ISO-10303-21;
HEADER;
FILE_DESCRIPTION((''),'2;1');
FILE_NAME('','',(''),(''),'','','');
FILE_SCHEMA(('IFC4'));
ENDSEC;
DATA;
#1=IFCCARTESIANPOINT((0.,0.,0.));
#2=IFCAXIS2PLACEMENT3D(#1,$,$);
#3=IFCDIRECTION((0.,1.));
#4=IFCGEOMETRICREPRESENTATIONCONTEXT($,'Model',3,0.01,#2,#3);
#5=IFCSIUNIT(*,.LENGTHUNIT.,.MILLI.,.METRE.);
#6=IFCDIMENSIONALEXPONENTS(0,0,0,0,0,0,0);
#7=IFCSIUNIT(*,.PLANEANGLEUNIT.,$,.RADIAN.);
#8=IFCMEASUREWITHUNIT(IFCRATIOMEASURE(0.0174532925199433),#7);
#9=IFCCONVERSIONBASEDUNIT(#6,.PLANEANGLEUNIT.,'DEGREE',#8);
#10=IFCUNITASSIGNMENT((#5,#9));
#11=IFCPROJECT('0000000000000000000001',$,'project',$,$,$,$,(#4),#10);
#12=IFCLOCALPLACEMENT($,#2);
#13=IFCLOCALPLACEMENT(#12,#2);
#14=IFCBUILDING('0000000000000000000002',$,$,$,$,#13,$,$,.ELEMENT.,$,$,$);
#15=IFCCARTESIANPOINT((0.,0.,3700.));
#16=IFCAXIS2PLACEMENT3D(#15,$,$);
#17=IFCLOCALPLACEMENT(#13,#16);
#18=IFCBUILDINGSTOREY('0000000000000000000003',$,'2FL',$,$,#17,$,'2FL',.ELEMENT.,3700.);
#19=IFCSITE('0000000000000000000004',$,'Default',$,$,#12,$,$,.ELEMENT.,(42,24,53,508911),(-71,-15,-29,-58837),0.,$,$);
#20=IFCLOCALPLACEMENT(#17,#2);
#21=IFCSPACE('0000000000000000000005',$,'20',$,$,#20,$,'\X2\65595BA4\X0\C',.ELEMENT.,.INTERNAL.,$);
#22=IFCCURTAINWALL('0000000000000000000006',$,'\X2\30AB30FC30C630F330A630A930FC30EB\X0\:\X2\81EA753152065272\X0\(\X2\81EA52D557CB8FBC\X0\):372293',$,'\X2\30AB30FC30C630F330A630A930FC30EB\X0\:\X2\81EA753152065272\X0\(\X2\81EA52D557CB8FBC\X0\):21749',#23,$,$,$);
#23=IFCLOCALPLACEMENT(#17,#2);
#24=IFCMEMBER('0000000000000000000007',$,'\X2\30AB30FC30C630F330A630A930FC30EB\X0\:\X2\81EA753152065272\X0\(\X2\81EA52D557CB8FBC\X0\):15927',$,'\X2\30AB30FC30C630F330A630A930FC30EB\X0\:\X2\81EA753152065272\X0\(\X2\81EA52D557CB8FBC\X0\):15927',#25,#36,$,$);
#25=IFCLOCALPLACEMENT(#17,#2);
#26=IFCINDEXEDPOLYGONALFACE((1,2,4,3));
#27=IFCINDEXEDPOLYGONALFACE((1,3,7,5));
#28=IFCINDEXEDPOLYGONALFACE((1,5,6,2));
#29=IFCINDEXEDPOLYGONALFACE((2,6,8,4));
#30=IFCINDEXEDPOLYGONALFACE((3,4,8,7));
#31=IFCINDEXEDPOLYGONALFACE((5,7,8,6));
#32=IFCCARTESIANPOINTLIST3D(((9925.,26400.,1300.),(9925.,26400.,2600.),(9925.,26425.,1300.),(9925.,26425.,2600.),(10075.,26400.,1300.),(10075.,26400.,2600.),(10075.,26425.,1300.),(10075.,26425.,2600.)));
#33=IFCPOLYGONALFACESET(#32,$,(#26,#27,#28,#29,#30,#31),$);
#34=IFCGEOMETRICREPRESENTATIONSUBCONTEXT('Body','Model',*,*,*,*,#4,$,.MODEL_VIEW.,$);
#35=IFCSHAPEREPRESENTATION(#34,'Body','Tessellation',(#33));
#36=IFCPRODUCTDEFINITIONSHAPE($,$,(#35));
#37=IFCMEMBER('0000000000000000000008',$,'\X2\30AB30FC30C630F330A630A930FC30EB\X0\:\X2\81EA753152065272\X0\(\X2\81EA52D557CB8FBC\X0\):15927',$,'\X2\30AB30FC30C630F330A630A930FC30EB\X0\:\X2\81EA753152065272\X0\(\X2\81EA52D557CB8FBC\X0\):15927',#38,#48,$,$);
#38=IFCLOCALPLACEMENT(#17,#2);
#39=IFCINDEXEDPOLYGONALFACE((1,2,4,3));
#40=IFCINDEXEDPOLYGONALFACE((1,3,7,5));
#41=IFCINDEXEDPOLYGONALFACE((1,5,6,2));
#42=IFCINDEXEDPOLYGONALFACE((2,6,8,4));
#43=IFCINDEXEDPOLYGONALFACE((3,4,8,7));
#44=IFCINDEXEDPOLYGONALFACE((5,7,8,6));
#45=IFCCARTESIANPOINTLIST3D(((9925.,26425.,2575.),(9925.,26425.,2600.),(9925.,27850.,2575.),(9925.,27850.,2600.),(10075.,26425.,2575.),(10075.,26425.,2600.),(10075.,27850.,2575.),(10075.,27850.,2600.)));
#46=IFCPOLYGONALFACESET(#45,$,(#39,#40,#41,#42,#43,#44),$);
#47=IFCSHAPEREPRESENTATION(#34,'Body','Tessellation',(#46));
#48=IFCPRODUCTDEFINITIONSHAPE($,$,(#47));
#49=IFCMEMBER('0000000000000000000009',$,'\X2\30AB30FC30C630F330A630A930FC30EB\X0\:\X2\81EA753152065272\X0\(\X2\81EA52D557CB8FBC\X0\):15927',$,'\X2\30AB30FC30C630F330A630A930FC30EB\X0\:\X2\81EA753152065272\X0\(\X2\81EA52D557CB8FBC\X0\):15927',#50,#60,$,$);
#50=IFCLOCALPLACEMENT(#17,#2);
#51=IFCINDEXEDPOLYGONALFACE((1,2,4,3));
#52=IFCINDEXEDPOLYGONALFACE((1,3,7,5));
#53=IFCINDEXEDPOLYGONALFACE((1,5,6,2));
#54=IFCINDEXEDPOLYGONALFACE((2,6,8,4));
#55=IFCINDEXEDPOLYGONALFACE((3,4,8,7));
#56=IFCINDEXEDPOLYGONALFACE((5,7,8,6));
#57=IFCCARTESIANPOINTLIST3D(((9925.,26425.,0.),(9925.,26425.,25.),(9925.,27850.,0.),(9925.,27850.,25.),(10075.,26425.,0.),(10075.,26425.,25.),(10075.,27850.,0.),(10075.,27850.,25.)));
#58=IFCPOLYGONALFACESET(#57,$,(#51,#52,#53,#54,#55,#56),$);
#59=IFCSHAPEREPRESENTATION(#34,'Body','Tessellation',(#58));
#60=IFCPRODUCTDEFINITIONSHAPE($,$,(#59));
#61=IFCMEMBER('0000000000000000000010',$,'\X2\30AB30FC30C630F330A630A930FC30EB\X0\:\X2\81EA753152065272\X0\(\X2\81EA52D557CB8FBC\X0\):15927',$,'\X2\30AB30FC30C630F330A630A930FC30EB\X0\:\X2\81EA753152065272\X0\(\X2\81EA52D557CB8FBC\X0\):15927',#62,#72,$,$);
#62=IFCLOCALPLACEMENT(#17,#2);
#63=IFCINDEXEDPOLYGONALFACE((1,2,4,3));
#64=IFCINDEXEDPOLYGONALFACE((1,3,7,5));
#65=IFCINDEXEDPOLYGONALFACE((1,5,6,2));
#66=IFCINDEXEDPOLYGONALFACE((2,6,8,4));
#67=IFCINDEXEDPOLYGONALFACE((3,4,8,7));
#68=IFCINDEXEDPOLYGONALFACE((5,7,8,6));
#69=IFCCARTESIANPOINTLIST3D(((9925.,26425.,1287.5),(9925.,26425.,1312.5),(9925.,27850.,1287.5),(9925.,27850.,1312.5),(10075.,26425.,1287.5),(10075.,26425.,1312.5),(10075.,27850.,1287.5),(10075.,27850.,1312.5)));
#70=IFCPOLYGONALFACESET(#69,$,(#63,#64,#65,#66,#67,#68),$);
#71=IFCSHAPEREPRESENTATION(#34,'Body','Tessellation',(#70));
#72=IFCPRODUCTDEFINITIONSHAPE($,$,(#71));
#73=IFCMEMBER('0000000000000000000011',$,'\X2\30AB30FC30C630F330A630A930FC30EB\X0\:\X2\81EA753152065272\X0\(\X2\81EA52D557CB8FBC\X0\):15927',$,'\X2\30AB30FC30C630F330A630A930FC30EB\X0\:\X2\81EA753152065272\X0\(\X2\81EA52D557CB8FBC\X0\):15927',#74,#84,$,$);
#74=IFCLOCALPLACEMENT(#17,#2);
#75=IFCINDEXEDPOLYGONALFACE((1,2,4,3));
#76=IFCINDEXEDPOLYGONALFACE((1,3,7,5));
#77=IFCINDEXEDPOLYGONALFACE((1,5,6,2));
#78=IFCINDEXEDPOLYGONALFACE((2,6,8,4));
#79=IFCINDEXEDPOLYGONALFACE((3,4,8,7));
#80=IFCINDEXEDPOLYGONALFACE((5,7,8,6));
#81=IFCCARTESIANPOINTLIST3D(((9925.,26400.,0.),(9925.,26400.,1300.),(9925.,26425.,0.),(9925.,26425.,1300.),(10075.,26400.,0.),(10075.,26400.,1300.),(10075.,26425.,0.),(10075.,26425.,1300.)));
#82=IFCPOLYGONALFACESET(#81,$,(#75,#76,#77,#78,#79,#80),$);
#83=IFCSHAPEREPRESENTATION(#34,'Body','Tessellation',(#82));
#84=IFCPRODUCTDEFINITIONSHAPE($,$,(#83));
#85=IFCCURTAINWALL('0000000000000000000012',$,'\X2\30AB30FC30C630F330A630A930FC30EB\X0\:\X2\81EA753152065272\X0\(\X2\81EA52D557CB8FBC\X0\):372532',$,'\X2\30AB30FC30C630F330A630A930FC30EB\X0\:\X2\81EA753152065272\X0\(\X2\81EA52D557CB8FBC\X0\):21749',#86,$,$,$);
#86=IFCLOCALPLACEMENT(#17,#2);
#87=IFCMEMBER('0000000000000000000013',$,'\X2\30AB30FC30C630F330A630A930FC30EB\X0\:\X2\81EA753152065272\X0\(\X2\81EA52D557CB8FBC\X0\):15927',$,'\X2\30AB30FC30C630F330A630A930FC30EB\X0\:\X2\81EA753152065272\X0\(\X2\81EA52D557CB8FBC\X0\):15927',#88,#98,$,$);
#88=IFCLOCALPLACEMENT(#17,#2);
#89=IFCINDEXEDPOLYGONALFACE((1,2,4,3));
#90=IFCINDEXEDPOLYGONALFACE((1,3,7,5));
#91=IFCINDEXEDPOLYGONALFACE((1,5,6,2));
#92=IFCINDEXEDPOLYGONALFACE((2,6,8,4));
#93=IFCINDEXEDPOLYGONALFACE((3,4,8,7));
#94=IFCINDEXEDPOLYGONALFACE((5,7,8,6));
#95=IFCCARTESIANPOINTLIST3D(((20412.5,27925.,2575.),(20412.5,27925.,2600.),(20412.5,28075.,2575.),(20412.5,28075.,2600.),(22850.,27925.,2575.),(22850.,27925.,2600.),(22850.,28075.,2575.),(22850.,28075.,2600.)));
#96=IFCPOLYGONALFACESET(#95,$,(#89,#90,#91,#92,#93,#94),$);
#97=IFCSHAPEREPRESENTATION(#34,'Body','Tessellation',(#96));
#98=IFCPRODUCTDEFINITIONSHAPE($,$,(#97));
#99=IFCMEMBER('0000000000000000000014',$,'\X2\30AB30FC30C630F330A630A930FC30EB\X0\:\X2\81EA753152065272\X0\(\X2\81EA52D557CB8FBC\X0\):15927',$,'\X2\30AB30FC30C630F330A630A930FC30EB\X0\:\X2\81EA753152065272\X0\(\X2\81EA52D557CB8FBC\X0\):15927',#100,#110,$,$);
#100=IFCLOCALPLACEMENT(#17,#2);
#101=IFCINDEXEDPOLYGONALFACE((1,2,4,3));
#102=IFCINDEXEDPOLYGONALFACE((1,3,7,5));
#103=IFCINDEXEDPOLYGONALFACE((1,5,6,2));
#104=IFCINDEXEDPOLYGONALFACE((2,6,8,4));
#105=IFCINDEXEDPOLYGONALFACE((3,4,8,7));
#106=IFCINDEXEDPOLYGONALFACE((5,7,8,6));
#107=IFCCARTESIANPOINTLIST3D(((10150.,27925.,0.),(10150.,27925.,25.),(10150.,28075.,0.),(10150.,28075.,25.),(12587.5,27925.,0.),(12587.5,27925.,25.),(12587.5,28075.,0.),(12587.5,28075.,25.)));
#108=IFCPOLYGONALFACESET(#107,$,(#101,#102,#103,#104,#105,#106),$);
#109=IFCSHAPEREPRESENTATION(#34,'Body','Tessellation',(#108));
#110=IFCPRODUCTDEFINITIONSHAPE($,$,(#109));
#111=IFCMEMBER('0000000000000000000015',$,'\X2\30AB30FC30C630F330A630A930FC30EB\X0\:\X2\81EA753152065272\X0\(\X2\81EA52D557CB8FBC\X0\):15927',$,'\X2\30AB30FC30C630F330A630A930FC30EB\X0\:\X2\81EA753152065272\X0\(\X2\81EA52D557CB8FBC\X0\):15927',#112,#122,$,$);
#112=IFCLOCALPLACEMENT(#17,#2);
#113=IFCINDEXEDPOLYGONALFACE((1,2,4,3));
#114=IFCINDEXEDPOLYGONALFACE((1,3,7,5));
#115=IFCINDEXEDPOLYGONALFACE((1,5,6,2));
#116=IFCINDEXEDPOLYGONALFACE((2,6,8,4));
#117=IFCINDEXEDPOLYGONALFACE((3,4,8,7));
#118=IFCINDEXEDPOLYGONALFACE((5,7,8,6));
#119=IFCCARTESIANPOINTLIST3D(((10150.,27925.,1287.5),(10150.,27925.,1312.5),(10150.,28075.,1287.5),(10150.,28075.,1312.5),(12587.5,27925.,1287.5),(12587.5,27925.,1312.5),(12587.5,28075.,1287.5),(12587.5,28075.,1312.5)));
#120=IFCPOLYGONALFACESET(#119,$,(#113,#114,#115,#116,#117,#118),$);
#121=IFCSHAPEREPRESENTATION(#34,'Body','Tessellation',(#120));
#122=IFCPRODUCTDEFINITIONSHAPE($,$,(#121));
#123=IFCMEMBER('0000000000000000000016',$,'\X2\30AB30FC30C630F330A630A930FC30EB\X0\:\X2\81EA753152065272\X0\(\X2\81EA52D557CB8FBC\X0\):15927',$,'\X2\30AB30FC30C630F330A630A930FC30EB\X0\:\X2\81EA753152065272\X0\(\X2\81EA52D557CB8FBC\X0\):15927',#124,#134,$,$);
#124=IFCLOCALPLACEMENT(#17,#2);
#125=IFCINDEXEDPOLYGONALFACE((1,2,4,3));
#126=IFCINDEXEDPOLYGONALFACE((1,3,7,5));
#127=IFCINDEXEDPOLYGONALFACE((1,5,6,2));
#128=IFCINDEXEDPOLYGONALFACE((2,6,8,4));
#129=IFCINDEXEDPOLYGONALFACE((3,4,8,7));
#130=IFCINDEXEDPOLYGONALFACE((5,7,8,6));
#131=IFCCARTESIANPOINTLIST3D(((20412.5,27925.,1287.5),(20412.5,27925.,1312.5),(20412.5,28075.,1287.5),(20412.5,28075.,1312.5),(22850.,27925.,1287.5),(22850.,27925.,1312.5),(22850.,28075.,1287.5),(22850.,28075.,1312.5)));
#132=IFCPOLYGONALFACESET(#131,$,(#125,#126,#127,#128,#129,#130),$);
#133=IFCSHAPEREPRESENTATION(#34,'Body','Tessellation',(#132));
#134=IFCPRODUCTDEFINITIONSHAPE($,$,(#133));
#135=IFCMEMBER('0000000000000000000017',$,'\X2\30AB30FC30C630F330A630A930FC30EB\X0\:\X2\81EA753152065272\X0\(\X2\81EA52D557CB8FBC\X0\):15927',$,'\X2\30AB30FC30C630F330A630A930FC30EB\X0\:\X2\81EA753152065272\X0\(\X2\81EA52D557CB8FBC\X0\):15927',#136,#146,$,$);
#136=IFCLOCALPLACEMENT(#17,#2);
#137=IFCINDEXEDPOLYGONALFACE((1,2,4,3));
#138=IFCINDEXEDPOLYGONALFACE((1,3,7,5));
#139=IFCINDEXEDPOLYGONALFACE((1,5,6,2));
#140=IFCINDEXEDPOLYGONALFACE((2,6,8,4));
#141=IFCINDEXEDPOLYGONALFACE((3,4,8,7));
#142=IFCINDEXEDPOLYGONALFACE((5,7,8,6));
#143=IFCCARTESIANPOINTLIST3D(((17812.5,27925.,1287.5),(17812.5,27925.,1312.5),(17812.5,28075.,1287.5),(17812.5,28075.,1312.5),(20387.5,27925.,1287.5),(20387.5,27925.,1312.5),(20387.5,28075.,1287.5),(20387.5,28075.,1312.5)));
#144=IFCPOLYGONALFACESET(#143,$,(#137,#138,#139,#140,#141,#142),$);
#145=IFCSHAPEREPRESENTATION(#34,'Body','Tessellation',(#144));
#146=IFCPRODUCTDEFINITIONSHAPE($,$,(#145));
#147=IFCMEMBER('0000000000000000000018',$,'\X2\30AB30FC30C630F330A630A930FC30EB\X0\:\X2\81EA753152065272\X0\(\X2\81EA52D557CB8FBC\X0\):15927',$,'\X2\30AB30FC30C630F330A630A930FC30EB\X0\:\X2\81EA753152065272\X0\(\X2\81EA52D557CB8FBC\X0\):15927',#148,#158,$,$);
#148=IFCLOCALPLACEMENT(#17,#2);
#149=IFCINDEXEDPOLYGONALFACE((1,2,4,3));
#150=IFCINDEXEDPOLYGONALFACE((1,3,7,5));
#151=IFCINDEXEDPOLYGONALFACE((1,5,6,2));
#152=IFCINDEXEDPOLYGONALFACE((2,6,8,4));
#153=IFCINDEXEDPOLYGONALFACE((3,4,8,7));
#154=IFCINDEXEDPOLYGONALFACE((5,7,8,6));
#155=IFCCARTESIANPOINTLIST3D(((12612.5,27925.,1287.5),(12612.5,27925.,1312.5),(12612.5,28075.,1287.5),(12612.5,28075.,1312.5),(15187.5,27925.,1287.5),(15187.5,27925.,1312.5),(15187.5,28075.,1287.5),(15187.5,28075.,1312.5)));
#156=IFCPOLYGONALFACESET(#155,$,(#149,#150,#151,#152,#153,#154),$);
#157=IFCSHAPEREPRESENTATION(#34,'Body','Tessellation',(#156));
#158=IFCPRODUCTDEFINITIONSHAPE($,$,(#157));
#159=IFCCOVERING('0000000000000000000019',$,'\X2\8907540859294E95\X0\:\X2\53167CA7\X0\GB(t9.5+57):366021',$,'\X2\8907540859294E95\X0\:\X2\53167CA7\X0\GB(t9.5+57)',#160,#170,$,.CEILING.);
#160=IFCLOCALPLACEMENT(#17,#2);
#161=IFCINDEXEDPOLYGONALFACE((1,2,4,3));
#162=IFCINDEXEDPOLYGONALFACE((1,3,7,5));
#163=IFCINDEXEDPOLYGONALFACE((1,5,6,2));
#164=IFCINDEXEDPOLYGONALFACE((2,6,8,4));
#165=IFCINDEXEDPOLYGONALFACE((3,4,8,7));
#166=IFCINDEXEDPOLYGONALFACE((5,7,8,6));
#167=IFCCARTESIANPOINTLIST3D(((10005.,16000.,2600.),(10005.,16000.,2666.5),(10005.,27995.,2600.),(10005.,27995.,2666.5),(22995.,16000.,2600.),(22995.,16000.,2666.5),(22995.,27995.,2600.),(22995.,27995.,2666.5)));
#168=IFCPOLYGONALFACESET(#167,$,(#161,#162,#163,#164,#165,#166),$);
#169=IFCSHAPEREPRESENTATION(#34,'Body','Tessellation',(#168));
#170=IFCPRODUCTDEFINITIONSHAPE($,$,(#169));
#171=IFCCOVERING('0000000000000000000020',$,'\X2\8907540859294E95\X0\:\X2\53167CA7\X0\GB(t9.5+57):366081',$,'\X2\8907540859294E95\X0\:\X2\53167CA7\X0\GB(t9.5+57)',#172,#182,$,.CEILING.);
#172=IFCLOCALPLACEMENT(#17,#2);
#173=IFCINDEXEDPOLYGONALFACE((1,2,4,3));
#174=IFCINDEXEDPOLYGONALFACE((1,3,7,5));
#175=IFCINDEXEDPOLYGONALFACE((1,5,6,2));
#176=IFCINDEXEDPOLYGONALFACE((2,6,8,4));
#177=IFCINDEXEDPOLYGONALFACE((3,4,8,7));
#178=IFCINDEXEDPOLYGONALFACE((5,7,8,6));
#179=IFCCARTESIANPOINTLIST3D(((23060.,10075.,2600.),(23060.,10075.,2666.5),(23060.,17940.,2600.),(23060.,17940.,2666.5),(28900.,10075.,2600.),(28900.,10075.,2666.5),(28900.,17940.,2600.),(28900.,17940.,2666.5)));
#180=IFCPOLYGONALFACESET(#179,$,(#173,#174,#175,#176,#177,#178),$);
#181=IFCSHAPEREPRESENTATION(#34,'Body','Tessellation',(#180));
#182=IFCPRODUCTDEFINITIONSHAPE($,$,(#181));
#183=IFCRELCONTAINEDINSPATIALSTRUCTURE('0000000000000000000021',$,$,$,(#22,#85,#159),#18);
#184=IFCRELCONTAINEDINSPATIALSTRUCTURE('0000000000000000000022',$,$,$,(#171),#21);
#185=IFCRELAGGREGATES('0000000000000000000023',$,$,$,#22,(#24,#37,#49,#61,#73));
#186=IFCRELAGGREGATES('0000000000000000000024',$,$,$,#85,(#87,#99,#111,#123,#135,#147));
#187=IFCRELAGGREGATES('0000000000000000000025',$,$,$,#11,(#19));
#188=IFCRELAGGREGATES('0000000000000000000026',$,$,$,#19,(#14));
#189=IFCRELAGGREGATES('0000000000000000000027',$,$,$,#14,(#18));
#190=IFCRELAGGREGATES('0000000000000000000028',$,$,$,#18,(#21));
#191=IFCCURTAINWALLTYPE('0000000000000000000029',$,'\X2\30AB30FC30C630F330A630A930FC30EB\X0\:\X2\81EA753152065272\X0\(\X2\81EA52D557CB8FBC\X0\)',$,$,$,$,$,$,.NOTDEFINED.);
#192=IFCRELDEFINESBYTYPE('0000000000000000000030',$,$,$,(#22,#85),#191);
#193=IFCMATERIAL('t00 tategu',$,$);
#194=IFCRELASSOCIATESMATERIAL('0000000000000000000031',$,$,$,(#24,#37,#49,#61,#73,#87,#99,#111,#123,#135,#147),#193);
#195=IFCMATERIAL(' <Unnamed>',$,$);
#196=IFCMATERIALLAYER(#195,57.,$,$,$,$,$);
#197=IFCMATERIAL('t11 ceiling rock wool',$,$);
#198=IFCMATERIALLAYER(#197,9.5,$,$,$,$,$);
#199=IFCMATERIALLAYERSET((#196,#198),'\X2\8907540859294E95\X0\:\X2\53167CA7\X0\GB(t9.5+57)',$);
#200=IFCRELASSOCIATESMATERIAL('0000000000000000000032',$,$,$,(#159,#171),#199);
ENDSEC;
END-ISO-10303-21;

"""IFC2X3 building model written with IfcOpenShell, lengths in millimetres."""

from ifc_helpers import new_model, entity, si_unit, converted_unit, direction, frame, frame_2d, origin, origin_2d_with_axis, place, context, subcontext, project, spatial, rectangle, extrude, material, layer, layer_set, layer_usage, type_object, element, aggregate, save


model = new_model("IFC2X3")

# Units and contexts
model_context = context("Model", 3, precision=0.01, world=origin(), true_north=direction((0.0, 1.0)))
body_context = subcontext(model_context, "Body", "Model", "MODEL_VIEW")
ifc_project = project(units=[si_unit("LENGTHUNIT", "METRE", prefix="MILLI"), converted_unit("PLANEANGLEUNIT", "DEGREE", entity("IfcRatioMeasure", 0.0174532925199433), si_unit("PLANEANGLEUNIT", "RADIAN"), dimensions=[0, 0, 0, 0, 0, 0, 0])], contexts=[model_context])

# Site, building, storey
site_placement = place(None, origin())
site = spatial("IfcSite", under=ifc_project, at=site_placement, Name="Default", CompositionType="ELEMENT", RefLatitude=(42, 24, 53, 508911), RefLongitude=(-71, -15, -29, -58837), RefElevation=0.0)
building_placement = place(site_placement, origin())
building = spatial("IfcBuilding", under=site, at=building_placement, CompositionType="ELEMENT")
storey_placement = place(building_placement, frame((0.0, 0.0, 3700.0)))
storey = spatial("IfcBuildingStorey", under=building, at=storey_placement, Name="2FL", LongName="2FL", CompositionType="ELEMENT", Elevation=3700.0)

# Curtain walls, members
curtain_wall_type = type_object("IfcCurtainWallType", Name="カーテンウォール:自由分割(自動埋込)", PredefinedType="NOTDEFINED")
curtain_wall_1_placement = place(storey_placement, frame((0.0, 0.0, -3700.0)))
curtain_wall_1 = element("IfcCurtainWall", 1, at=curtain_wall_1_placement, inside=storey, type_object=curtain_wall_type, Name="カーテンウォール:自由分割(自動埋込):372293", ObjectType="カーテンウォール:自由分割(自動埋込):21749")
ifc_material_1 = material(Name="t00 tategu")
member_1_placement = place(curtain_wall_1_placement, frame((0.0, 0.0, 3700.0)))
member_1 = element("IfcMember", 2, at=member_1_placement, material=ifc_material_1, Name="カーテンウォール:自由分割(自動埋込):15927", ObjectType="カーテンウォール:自由分割(自動埋込):15927", context=body_context, shape_type="SweptSolid", body=[
    extrude(rectangle(XDim=150.0, YDim=25.0, at=frame_2d((0.0, 0.0), x_axis=(1.0, 0.0))), frame((10000.0, 26412.5, 2600.0), z_axis=(0.0, 0.0, -1.0), x_axis=(-1.0, 0.0, 0.0)), (0.0, 0.0, 1.0), 1300.0),
])
member_2_placement = place(curtain_wall_1_placement, frame((0.0, 0.0, 3700.0)))
member_2 = element("IfcMember", 3, at=member_2_placement, material=ifc_material_1, Name="カーテンウォール:自由分割(自動埋込):15927", ObjectType="カーテンウォール:自由分割(自動埋込):15927", context=body_context, shape_type="SweptSolid", body=[
    extrude(rectangle(XDim=25.0, YDim=150.0, at=frame_2d((0.0, 0.0), x_axis=(1.0, 0.0))), frame((10000.0, 27850.0, 2587.5), z_axis=(0.0, -1.0, 0.0), x_axis=(0.0, 0.0, -1.0)), (0.0, 0.0, 1.0), 1425.0),
])
member_3_placement = place(curtain_wall_1_placement, frame((0.0, 0.0, 3700.0)))
member_3 = element("IfcMember", 4, at=member_3_placement, material=ifc_material_1, Name="カーテンウォール:自由分割(自動埋込):15927", ObjectType="カーテンウォール:自由分割(自動埋込):15927", context=body_context, shape_type="SweptSolid", body=[
    extrude(rectangle(XDim=25.0, YDim=150.0, at=origin_2d_with_axis()), frame((10000.0, 26425.0, 12.5), z_axis=(0.0, 1.0, 0.0), x_axis=(0.0, 0.0, -1.0)), (0.0, 0.0, 1.0), 1425.0),
])
member_4_placement = place(curtain_wall_1_placement, frame((0.0, 0.0, 3700.0)))
member_4 = element("IfcMember", 5, at=member_4_placement, material=ifc_material_1, Name="カーテンウォール:自由分割(自動埋込):15927", ObjectType="カーテンウォール:自由分割(自動埋込):15927", context=body_context, shape_type="SweptSolid", body=[
    extrude(rectangle(XDim=25.0, YDim=150.0, at=origin_2d_with_axis()), frame((10000.0, 27850.0, 1300.0), z_axis=(0.0, -1.0, 0.0), x_axis=(0.0, 0.0, -1.0)), (0.0, 0.0, 1.0), 1425.0),
])
member_5_placement = place(curtain_wall_1_placement, frame((0.0, 0.0, 3700.0)))
member_5 = element("IfcMember", 6, at=member_5_placement, material=ifc_material_1, Name="カーテンウォール:自由分割(自動埋込):15927", ObjectType="カーテンウォール:自由分割(自動埋込):15927", context=body_context, shape_type="SweptSolid", body=[
    extrude(rectangle(XDim=150.0, YDim=25.0, at=frame_2d((0.0, 0.0), x_axis=(1.0, 0.0))), frame((10000.0, 26412.5, 1300.0), z_axis=(0.0, 0.0, -1.0), x_axis=(-1.0, 0.0, 0.0)), (0.0, 0.0, 1.0), 1300.0),
])
aggregate(curtain_wall_1, [member_1, member_2, member_3, member_4, member_5])
curtain_wall_2_placement = place(storey_placement, frame((0.0, 0.0, -3700.0)))
curtain_wall_2 = element("IfcCurtainWall", 7, at=curtain_wall_2_placement, inside=storey, type_object=curtain_wall_type, Name="カーテンウォール:自由分割(自動埋込):372532", ObjectType="カーテンウォール:自由分割(自動埋込):21749")
member_6_placement = place(curtain_wall_2_placement, frame((0.0, 0.0, 3700.0)))
member_6 = element("IfcMember", 8, at=member_6_placement, material=ifc_material_1, Name="カーテンウォール:自由分割(自動埋込):15927", ObjectType="カーテンウォール:自由分割(自動埋込):15927", context=body_context, shape_type="SweptSolid", body=[
    extrude(rectangle(XDim=25.0, YDim=150.0, at=frame_2d((0.0, 0.0), x_axis=(1.0, 0.0))), frame((22850.0, 28000.0, 2587.5), z_axis=(-1.0, 0.0, 0.0), x_axis=(0.0, 0.0, -1.0)), (0.0, 0.0, 1.0), 2437.5),
])
member_7_placement = place(curtain_wall_2_placement, frame((0.0, 0.0, 3700.0)))
member_7 = element("IfcMember", 9, at=member_7_placement, material=ifc_material_1, Name="カーテンウォール:自由分割(自動埋込):15927", ObjectType="カーテンウォール:自由分割(自動埋込):15927", context=body_context, shape_type="SweptSolid", body=[
    extrude(rectangle(XDim=25.0, YDim=150.0, at=frame_2d((0.0, 0.0), x_axis=(1.0, 0.0))), frame((10150.0, 28000.0, 12.5), z_axis=(1.0, 0.0, 0.0), x_axis=(0.0, 0.0, -1.0)), (0.0, 0.0, 1.0), 2437.5),
])
member_8_placement = place(curtain_wall_2_placement, frame((0.0, 0.0, 3700.0)))
member_8 = element("IfcMember", 10, at=member_8_placement, material=ifc_material_1, Name="カーテンウォール:自由分割(自動埋込):15927", ObjectType="カーテンウォール:自由分割(自動埋込):15927", context=body_context, shape_type="SweptSolid", body=[
    extrude(rectangle(XDim=25.0, YDim=150.0, at=frame_2d((0.0, 0.0), x_axis=(1.0, 0.0))), frame((12587.5, 28000.0, 1300.0), z_axis=(-1.0, 0.0, 0.0), x_axis=(0.0, 0.0, -1.0)), (0.0, 0.0, 1.0), 2437.5),
])
member_9_placement = place(curtain_wall_2_placement, frame((0.0, 0.0, 3700.0)))
member_9 = element("IfcMember", 11, at=member_9_placement, material=ifc_material_1, Name="カーテンウォール:自由分割(自動埋込):15927", ObjectType="カーテンウォール:自由分割(自動埋込):15927", context=body_context, shape_type="SweptSolid", body=[
    extrude(rectangle(XDim=25.0, YDim=150.0, at=frame_2d((0.0, 0.0), x_axis=(1.0, 0.0))), frame((22850.0, 28000.0, 1300.0), z_axis=(-1.0, 0.0, 0.0), x_axis=(0.0, 0.0, -1.0)), (0.0, 0.0, 1.0), 2437.5),
])
member_10_placement = place(curtain_wall_2_placement, frame((0.0, 0.0, 3700.0)))
member_10 = element("IfcMember", 12, at=member_10_placement, material=ifc_material_1, Name="カーテンウォール:自由分割(自動埋込):15927", ObjectType="カーテンウォール:自由分割(自動埋込):15927", context=body_context, shape_type="SweptSolid", body=[
    extrude(rectangle(XDim=25.0, YDim=150.0, at=frame_2d((0.0, 0.0), x_axis=(1.0, 0.0))), frame((20387.5, 28000.0, 1300.0), z_axis=(-1.0, 0.0, 0.0), x_axis=(0.0, 0.0, -1.0)), (0.0, 0.0, 1.0), 2575.0),
])
member_11_placement = place(curtain_wall_2_placement, frame((0.0, 0.0, 3700.0)))
member_11 = element("IfcMember", 13, at=member_11_placement, material=ifc_material_1, Name="カーテンウォール:自由分割(自動埋込):15927", ObjectType="カーテンウォール:自由分割(自動埋込):15927", context=body_context, shape_type="SweptSolid", body=[
    extrude(rectangle(XDim=25.0, YDim=150.0, at=frame_2d((0.0, 0.0), x_axis=(1.0, 0.0))), frame((15187.5, 28000.0, 1300.0), z_axis=(-1.0, 0.0, 0.0), x_axis=(0.0, 0.0, -1.0)), (0.0, 0.0, 1.0), 2575.0),
])
aggregate(curtain_wall_2, [member_6, member_7, member_8, member_9, member_10, member_11])

# Covering
ifc_material_2 = material(Name=" <Unnamed>")
ifc_layer_1 = layer(ifc_material_2, 57.0)
ifc_material_3 = material(Name="t11 ceiling rock wool")
ifc_layer_2 = layer(ifc_material_3, 9.5)
ifc_layer_set = layer_set([ifc_layer_1, ifc_layer_2], Name="複合天井:化粧GB(t9.5+57)")
ifc_layer_usage_1 = layer_usage(ifc_layer_set, "AXIS3", "NEGATIVE", 0.0)
covering_1_placement = place(storey_placement, origin())
element("IfcCovering", 14, at=covering_1_placement, inside=storey, material=ifc_layer_usage_1, Name="複合天井:化粧GB(t9.5+57):366021", ObjectType="複合天井:化粧GB(t9.5+57)", PredefinedType="CEILING", context=body_context, shape_type="SweptSolid", body=[
    extrude(rectangle(XDim=12990.0, YDim=11995.0, at=frame_2d((0.0, 0.0), x_axis=(1.0, 0.0))), frame((16500.0, 21997.5, 2600.0), z_axis=(0.0, 0.0, 1.0), x_axis=(-1.0, 0.0, 0.0)), (0.0, 0.0, 1.0), 66.5),
])

# Shared definitions
space_1_placement = place(storey_placement, origin())
space_1 = spatial("IfcSpace", under=storey, at=space_1_placement, Name="20", LongName="教室C", CompositionType="ELEMENT", InteriorOrExteriorSpace="INTERNAL")

# Covering
ifc_layer_usage_2 = layer_usage(ifc_layer_set, "AXIS3", "NEGATIVE", 0.0)
covering_2_placement = place(space_1_placement, origin())
element("IfcCovering", 15, at=covering_2_placement, inside=space_1, material=ifc_layer_usage_2, Name="複合天井:化粧GB(t9.5+57):366081", ObjectType="複合天井:化粧GB(t9.5+57)", PredefinedType="CEILING", context=body_context, shape_type="SweptSolid", body=[
    extrude(rectangle(XDim=5840.0, YDim=7865.0, at=frame_2d((0.0, 0.0), x_axis=(1.0, 0.0))), frame((25980.0, 14007.5, 2600.0), z_axis=(0.0, 0.0, 1.0), x_axis=(-1.0, 0.0, 0.0)), (0.0, 0.0, 1.0), 66.5),
])

save(model, "model.ifc")
